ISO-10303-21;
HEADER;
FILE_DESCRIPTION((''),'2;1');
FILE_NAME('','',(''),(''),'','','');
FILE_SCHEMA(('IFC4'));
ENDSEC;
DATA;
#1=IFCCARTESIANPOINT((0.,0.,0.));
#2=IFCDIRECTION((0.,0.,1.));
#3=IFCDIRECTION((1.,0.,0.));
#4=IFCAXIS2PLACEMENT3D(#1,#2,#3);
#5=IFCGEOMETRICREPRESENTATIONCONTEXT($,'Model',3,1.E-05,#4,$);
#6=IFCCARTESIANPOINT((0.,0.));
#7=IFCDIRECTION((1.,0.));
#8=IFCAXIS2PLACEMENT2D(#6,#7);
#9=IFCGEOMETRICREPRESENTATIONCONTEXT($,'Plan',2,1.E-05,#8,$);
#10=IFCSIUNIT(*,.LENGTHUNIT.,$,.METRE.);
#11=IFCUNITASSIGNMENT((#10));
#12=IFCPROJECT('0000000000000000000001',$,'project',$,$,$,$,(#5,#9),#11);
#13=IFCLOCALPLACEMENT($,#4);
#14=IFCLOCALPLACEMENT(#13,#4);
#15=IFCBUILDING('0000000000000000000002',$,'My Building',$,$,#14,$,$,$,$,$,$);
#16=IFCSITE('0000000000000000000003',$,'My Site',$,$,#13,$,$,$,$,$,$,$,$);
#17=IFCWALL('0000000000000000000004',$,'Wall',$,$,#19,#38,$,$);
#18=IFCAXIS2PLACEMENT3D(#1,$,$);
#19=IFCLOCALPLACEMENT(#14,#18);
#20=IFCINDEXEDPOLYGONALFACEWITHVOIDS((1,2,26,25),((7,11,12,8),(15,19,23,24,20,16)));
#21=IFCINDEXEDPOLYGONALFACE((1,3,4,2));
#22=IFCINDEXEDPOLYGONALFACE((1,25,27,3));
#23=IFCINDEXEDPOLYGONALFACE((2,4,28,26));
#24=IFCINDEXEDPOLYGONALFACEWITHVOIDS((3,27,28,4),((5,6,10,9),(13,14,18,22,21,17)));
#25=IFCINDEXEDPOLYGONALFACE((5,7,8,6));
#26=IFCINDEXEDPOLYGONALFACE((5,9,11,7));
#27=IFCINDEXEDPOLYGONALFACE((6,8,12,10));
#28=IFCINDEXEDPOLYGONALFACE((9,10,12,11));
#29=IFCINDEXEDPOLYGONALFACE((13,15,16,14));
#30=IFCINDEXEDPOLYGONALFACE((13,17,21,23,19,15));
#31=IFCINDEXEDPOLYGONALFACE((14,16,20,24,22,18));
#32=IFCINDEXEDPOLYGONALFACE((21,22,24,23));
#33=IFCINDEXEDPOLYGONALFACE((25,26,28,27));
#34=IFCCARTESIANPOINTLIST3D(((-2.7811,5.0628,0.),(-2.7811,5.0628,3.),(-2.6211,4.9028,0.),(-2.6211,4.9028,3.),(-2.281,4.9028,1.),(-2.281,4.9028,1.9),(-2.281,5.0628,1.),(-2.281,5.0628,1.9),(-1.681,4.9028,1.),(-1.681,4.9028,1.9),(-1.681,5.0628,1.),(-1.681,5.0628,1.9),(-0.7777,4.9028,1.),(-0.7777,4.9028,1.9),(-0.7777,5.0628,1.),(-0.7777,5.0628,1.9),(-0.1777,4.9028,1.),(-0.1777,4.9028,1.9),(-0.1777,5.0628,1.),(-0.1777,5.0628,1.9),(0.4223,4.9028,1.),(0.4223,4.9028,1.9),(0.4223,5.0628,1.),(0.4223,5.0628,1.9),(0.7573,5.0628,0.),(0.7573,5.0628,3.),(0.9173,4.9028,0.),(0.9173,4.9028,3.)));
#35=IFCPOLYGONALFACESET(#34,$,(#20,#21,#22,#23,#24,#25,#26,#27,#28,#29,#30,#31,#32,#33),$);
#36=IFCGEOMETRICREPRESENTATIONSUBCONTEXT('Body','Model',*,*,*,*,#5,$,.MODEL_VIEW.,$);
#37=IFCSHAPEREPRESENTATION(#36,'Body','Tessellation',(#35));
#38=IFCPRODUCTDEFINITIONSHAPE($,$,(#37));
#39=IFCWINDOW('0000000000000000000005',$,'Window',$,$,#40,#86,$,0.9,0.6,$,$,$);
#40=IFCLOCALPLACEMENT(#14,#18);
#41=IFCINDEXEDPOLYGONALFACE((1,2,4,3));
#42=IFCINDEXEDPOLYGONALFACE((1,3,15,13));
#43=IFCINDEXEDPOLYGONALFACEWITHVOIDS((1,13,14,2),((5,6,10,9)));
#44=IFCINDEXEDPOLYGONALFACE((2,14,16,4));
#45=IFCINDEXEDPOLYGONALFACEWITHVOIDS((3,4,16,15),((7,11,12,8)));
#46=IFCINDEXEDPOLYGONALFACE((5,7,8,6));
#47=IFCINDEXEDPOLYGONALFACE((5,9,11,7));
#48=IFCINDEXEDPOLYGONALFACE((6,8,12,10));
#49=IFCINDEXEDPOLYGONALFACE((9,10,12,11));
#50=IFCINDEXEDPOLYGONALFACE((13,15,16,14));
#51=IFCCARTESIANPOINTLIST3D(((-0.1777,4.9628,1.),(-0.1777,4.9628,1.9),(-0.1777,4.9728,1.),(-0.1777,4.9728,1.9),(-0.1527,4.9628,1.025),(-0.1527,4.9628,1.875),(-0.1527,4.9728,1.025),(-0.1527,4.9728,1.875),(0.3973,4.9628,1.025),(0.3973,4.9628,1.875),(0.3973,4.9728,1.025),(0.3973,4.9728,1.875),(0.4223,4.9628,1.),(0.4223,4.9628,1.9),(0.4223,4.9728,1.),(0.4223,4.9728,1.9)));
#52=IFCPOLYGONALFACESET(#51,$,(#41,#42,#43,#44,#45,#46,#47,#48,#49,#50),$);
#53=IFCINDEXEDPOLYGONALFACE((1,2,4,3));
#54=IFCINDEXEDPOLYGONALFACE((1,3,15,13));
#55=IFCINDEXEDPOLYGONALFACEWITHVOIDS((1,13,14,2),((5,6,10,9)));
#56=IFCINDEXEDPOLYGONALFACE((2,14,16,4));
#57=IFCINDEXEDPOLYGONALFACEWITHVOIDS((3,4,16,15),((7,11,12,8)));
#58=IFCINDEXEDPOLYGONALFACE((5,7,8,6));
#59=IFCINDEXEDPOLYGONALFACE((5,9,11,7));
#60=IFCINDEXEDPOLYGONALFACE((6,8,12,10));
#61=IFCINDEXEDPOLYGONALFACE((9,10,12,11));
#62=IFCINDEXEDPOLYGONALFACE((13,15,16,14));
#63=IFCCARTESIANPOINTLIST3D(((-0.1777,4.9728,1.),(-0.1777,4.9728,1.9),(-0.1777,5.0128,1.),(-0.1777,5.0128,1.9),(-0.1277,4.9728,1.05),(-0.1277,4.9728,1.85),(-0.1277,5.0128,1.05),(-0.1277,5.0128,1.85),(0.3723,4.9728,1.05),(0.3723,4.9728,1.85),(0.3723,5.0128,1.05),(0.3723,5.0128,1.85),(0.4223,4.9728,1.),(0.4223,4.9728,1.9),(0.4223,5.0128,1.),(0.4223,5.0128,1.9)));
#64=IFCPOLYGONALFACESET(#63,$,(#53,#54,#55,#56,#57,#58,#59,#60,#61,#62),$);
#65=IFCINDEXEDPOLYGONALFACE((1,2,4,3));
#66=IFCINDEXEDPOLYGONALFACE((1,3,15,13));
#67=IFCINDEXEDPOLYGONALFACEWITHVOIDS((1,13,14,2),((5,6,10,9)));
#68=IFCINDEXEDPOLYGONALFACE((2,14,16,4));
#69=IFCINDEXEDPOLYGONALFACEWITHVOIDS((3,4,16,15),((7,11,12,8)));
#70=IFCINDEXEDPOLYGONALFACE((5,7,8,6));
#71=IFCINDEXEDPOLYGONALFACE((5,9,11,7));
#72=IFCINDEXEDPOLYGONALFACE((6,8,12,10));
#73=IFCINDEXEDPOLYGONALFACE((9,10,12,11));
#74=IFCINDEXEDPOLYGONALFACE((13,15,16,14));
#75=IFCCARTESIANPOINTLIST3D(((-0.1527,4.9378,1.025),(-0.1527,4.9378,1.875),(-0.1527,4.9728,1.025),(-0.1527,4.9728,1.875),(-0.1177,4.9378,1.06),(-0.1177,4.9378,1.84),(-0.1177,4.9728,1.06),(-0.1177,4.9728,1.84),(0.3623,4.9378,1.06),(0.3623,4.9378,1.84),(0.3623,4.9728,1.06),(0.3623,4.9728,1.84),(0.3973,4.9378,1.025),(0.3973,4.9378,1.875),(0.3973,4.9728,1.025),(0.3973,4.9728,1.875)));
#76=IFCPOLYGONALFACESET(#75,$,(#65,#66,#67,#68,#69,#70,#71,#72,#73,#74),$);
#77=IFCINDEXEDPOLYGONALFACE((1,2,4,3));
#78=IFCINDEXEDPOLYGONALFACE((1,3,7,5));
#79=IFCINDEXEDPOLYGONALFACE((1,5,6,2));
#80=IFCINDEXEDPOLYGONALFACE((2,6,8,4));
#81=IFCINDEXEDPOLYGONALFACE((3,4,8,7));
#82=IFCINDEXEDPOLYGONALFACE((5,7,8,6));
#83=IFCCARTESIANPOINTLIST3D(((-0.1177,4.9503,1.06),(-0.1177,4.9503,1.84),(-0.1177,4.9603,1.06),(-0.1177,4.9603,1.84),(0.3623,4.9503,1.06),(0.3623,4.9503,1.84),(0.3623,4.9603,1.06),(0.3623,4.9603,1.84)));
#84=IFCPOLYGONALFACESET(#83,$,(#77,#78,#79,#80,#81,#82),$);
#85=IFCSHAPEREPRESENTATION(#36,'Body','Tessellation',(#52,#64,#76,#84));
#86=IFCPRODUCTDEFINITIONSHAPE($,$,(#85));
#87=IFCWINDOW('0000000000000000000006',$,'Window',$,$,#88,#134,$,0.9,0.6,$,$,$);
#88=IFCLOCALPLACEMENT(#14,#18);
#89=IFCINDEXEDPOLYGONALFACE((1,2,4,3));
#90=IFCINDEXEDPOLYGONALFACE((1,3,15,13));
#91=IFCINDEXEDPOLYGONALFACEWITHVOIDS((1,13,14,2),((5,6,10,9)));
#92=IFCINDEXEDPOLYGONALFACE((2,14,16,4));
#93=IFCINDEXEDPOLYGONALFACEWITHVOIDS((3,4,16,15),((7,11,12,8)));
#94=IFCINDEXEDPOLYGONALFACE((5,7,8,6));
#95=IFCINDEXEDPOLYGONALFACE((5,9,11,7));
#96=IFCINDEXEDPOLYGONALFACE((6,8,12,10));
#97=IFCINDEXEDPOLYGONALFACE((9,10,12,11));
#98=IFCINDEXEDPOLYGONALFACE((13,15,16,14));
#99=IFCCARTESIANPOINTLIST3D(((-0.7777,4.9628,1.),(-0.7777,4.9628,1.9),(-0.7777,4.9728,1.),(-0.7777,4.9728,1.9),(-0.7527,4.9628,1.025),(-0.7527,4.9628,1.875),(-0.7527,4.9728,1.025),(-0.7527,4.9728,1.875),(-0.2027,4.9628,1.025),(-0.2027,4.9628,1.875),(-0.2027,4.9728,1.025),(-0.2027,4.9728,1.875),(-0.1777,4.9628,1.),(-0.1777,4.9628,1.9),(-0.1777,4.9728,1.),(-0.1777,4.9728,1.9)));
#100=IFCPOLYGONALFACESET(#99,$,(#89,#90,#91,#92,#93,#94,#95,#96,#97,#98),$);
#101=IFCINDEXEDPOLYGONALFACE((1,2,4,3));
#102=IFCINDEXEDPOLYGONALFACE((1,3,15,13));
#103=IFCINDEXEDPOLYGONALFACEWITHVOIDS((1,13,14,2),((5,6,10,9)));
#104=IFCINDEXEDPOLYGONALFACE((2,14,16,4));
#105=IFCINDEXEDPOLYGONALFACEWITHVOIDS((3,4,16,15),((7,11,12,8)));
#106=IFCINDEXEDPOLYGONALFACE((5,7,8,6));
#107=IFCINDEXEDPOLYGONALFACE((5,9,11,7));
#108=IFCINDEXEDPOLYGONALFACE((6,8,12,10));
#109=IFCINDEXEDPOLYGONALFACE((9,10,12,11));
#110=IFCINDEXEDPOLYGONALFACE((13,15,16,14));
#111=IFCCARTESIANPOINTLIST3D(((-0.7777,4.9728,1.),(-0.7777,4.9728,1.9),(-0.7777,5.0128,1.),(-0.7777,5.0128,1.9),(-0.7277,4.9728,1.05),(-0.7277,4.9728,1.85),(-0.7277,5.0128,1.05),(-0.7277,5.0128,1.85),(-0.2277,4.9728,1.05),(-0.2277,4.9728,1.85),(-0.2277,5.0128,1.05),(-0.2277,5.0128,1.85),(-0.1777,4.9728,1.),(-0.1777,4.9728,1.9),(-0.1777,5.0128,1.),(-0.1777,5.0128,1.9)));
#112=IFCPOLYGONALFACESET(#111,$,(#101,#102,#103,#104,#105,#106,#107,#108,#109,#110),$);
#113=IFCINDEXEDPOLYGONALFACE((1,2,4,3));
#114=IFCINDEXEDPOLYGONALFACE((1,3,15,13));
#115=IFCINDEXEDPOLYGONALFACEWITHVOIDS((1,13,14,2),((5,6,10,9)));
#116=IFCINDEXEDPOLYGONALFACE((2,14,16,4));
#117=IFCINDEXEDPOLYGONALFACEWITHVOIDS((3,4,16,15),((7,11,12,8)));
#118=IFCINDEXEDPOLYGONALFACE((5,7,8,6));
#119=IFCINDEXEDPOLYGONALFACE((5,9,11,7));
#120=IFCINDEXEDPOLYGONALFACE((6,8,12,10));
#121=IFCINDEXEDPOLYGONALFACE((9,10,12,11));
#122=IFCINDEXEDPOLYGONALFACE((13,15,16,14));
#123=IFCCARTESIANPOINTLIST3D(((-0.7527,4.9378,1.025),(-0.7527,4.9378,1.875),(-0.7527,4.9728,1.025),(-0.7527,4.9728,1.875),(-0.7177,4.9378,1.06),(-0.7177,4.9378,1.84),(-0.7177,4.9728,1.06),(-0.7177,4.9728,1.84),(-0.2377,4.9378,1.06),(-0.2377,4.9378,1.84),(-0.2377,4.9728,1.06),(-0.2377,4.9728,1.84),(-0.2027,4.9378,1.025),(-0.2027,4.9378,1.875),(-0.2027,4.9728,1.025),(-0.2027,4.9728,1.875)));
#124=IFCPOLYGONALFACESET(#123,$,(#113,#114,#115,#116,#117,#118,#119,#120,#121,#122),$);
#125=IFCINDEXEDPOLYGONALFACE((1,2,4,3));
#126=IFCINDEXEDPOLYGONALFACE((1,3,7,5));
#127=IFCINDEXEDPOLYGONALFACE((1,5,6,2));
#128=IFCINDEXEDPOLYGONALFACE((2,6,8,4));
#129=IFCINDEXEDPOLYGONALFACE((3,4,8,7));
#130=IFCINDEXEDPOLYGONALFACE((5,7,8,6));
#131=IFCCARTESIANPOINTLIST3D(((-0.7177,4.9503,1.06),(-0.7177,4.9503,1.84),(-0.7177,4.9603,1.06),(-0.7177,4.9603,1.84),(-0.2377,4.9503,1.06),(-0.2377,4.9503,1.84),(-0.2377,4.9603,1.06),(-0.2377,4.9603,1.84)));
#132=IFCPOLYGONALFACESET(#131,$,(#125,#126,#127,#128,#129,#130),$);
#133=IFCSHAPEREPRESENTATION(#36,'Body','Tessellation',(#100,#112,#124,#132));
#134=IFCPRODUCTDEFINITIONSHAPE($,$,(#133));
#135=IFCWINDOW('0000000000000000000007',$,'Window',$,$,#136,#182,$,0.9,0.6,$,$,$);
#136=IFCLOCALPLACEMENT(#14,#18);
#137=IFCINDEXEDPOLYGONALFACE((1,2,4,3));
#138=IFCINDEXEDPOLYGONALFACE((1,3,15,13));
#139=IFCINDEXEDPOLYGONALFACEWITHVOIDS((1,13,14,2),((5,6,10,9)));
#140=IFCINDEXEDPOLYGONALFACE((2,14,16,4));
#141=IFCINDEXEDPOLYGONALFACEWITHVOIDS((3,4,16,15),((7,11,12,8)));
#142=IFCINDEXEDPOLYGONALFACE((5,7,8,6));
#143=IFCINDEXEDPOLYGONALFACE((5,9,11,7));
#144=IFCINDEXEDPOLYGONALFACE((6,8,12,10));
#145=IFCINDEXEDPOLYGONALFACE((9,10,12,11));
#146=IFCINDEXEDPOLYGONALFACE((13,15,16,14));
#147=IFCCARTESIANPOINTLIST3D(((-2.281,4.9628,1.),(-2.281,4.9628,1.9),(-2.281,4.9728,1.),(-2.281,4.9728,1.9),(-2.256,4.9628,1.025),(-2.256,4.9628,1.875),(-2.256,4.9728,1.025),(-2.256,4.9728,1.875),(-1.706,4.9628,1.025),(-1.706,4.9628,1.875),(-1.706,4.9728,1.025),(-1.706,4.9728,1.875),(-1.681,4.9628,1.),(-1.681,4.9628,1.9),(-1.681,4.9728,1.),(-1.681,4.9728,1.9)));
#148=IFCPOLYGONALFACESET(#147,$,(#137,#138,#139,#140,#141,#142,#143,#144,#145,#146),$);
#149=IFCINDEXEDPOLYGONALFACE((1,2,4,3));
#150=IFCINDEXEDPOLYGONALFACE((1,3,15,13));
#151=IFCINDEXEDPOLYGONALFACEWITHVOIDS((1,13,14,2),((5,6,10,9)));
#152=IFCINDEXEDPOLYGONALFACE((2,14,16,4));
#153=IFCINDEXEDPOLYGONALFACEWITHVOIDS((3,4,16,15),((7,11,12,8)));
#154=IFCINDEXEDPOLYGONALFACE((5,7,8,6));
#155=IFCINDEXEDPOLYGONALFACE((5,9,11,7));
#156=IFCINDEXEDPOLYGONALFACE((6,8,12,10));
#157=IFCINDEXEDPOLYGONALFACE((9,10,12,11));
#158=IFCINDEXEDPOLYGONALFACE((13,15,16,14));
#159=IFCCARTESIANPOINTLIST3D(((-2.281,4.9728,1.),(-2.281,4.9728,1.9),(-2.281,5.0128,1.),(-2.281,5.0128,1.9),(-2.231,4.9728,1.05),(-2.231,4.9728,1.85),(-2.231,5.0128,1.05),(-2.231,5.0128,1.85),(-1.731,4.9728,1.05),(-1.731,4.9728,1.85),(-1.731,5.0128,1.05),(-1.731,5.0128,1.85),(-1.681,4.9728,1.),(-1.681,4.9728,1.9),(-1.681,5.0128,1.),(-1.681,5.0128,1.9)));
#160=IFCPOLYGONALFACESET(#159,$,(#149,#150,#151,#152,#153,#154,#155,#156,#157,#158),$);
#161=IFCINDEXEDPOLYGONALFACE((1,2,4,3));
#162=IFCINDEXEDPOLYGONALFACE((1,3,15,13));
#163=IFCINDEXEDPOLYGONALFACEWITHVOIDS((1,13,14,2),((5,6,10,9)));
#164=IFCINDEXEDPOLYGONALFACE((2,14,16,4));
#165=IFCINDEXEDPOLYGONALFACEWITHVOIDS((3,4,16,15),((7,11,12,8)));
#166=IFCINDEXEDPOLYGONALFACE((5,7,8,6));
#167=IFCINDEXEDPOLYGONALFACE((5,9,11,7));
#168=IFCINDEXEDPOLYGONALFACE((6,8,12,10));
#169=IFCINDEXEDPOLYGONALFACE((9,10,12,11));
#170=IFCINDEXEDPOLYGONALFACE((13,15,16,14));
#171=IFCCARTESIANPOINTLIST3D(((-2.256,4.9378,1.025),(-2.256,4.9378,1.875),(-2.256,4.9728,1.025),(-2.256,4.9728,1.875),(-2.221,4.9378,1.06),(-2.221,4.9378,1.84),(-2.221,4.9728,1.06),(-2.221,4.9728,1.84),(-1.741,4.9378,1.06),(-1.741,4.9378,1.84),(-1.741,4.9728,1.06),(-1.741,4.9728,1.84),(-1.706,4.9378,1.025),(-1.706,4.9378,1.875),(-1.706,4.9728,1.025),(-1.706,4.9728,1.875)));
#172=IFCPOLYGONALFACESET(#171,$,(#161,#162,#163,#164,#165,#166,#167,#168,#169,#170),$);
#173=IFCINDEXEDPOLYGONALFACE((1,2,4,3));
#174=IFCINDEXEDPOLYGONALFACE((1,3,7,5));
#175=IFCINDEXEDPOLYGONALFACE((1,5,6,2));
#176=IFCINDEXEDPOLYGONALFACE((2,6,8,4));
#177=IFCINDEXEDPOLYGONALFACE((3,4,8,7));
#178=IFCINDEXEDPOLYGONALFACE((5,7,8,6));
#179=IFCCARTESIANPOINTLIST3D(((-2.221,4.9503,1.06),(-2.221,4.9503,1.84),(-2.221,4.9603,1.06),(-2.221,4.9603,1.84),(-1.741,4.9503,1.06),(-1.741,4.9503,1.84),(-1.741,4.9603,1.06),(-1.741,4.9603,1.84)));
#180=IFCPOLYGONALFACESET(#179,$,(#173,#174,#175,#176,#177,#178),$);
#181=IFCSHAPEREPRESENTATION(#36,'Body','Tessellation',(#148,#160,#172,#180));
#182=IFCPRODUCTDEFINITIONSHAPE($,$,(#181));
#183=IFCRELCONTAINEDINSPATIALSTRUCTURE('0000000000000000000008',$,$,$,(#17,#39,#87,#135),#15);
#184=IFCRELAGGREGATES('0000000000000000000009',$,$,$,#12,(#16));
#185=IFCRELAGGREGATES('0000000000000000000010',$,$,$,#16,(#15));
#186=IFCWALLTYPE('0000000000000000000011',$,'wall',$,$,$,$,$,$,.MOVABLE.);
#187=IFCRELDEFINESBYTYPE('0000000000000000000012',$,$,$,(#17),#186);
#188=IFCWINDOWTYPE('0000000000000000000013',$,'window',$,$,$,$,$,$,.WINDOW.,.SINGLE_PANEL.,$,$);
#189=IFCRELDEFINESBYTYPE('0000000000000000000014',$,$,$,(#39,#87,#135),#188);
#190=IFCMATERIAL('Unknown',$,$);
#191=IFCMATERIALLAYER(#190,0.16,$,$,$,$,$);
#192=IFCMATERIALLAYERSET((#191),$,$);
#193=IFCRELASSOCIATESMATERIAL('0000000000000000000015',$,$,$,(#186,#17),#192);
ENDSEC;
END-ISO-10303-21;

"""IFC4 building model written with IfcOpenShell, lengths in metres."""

from ifc_helpers import new_model, entity, si_unit, frame, origin_with_axes, origin_2d_with_axis, place, context, subcontext, project, spatial, line, indexed_curve, outline, extrude, shape, source, transform, mapped, material, layer, layer_set, layer_usage, type_object, type_shapes, element, fill, save


model = new_model("IFC4")

# Units and contexts
model_context = context("Model", 3, precision=1e-05, world=origin_with_axes())
plan_context = context("Plan", 2, precision=1e-05, world=origin_2d_with_axis())
body_context_1 = subcontext(model_context, "Body", "Model", "MODEL_VIEW")
body_context_2 = subcontext(plan_context, "Body", "Plan", "PLAN_VIEW")
ifc_project = project(units=[si_unit("LENGTHUNIT", "METRE")], contexts=[model_context, plan_context])

# Site, building
site_placement = place(None, origin_with_axes())
site = spatial("IfcSite", under=ifc_project, at=site_placement, Name="My Site")
building_placement = place(site_placement, origin_with_axes())
building = spatial("IfcBuilding", under=site, at=building_placement, Name="My Building")

# Shared definitions
ifc_material = material(Name="Unknown")

# Wall, openings, windows
ifc_layer_1 = layer(ifc_material, 0.16)
ifc_layer_set_1 = layer_set([ifc_layer_1])
ifc_layer_usage_1 = layer_usage(ifc_layer_set_1, "AXIS2", "POSITIVE", 0.0)
wall_type_1 = type_object("IfcWallType", Name="wall", PredefinedType="MOVABLE", material=ifc_layer_set_1)
wall_1_placement = place(building_placement, frame((-2.6211, 4.9028, 0.0), z_axis=(0.0, 0.0, 1.0), x_axis=(1.0, 0.0, 0.0)))
wall_1 = element("IfcWall", 1, at=wall_1_placement, inside=building, type_object=wall_type_1, material=ifc_layer_usage_1, Name="Wall", context=body_context_1, shape_type="SweptSolid", body=[
    extrude(outline(indexed_curve([(0.0, 0.0), (-0.16, 0.16), (3.3784, 0.16), (3.5384, 0.0)], segments=[line(1, 2, 3, 4, 1)])), origin_with_axes(), (0.0, 0.0, 1.0), 3.0),
])
shared_shape_1 = source(origin_with_axes(), body_context_1, "Body", "SweptSolid", [
    extrude(outline(indexed_curve([(0.0, 0.0), (0.6, 0.0), (0.6, 0.9), (0.0, 0.9)], segments=[line(1, 2, 3, 4, 1)])), frame((0.0, -0.6, 0.0), z_axis=(0.0, -1.0, 0.0), x_axis=(1.0, 0.0, 0.0)), (0.0, 0.0, -1.0), 1.2),
])
opening_1_placement = place(wall_1_placement, frame((3.0434, 0.16, 1.0), z_axis=(0.0, 0.0, 1.0), x_axis=(-1.0, 0.0, 0.0)))
opening_1 = element("IfcOpeningElement", 2, at=opening_1_placement, cuts=wall_1, PredefinedType="OPENING", context=body_context_1, shape_type="MappedRepresentation", body=[
    mapped(shared_shape_1, transform((0.0, 0.0, 0.0), x_axis=(1.0, 0.0, 0.0), y_axis=(0.0, 1.0, 0.0), z_axis=(0.0, 0.0, 1.0), scale=1.0)),
])
opening_2_placement = place(wall_1_placement, frame((2.4434, 0.16, 1.0), z_axis=(0.0, 0.0, 1.0), x_axis=(-1.0, 0.0, 0.0)))
opening_2 = element("IfcOpeningElement", 3, at=opening_2_placement, cuts=wall_1, PredefinedType="OPENING", context=body_context_1, shape_type="MappedRepresentation", body=[
    mapped(shared_shape_1, transform((0.0, 0.0, 0.0), x_axis=(1.0, 0.0, 0.0), y_axis=(0.0, 1.0, 0.0), z_axis=(0.0, 0.0, 1.0), scale=1.0)),
])
opening_3_placement = place(wall_1_placement, frame((0.9401, 0.16, 1.0), z_axis=(0.0, 0.0, 1.0), x_axis=(-1.0, 0.0, 0.0)))
opening_3 = element("IfcOpeningElement", 4, at=opening_3_placement, cuts=wall_1, PredefinedType="OPENING", context=body_context_1, shape_type="MappedRepresentation", body=[
    mapped(shared_shape_1, transform((0.0, 0.0, 0.0), x_axis=(1.0, 0.0, 0.0), y_axis=(0.0, 1.0, 0.0), z_axis=(0.0, 0.0, 1.0), scale=1.0)),
])
window_type = type_object("IfcWindowType", Name="window", PartitioningType="SINGLE_PANEL", PredefinedType="WINDOW")
shared_shape_2 = source(origin_with_axes(), body_context_1, "Body", "SweptSolid", [
    extrude(outline(indexed_curve([(0.0, 0.0), (0.6, 0.0), (0.6, 0.9), (0.0, 0.9)], segments=[line(1, 2, 3, 4, 1)]), holes=[indexed_curve([(0.025, 0.025), (0.575, 0.025), (0.575, 0.875), (0.025, 0.875)], segments=[line(1, 2, 3, 4, 1)])]), frame((0.0, 0.09, 0.0), z_axis=(0.0, -1.0, 0.0), x_axis=(1.0, 0.0, 0.0)), (0.0, 0.0, -1.0), 0.01),
    extrude(outline(indexed_curve([(0.0, 0.0), (0.6, 0.0), (0.6, 0.9), (0.0, 0.9)], segments=[line(1, 2, 3, 4, 1)]), holes=[indexed_curve([(0.05, 0.05), (0.55, 0.05), (0.55, 0.85), (0.05, 0.85)], segments=[line(1, 2, 3, 4, 1)])]), frame((0.0, 0.05, 0.0), z_axis=(0.0, -1.0, 0.0), x_axis=(1.0, 0.0, 0.0)), (0.0, 0.0, -1.0), 0.04),
    extrude(outline(indexed_curve([(0.0, 0.0), (0.55, 0.0), (0.55, 0.85), (0.0, 0.85)], segments=[line(1, 2, 3, 4, 1)]), holes=[indexed_curve([(0.035, 0.035), (0.515, 0.035), (0.515, 0.815), (0.035, 0.815)], segments=[line(1, 2, 3, 4, 1)])]), frame((0.025, 0.09, 0.025), z_axis=(0.0, -1.0, 0.0), x_axis=(1.0, 0.0, 0.0)), (0.0, 0.0, -1.0), 0.035),
    extrude(outline(indexed_curve([(0.035, 0.035), (0.515, 0.035), (0.515, 0.815), (0.035, 0.815)], segments=[line(1, 2, 3, 4, 1)])), frame((0.025, 0.1025, 0.025), z_axis=(0.0, -1.0, 0.0), x_axis=(1.0, 0.0, 0.0)), (0.0, 0.0, -1.0), 0.01),
])
shared_shape_3 = source(origin_with_axes(), body_context_2, "Body", "Curve2D", [
    entity("IfcIndexedPolyCurve", entity("IfcCartesianPointList2D", [[0.05, 0.05], [0.55, 0.05]])),
    entity("IfcIndexedPolyCurve", entity("IfcCartesianPointList2D", [[0.0, 0.1], [0.025, 0.1], [0.025, 0.09], [0.05, 0.09], [0.05, 0.05], [0.0, 0.05]]), [entity("IfcLineIndex", [1, 2, 3, 4, 5, 6, 1])]),
    entity("IfcIndexedPolyCurve", entity("IfcCartesianPointList2D", [[0.6, 0.1], [0.575, 0.1], [0.575, 0.09], [0.55, 0.09], [0.55, 0.05], [0.6, 0.05]]), [entity("IfcLineIndex", [1, 2, 3, 4, 5, 6, 1])]),
    entity("IfcIndexedPolyCurve", entity("IfcCartesianPointList2D", [[0.025, 0.09], [0.06, 0.09], [0.06, 0.125], [0.025, 0.125]]), [entity("IfcLineIndex", [1, 2, 3, 4, 1])]),
    entity("IfcIndexedPolyCurve", entity("IfcCartesianPointList2D", [[0.575, 0.09], [0.54, 0.09], [0.54, 0.125], [0.575, 0.125]]), [entity("IfcLineIndex", [1, 2, 3, 4, 1])]),
    entity("IfcIndexedPolyCurve", entity("IfcCartesianPointList2D", [[0.06, 0.09], [0.54, 0.09]])),
    entity("IfcIndexedPolyCurve", entity("IfcCartesianPointList2D", [[0.06, 0.125], [0.54, 0.125]])),
    entity("IfcIndexedPolyCurve", entity("IfcCartesianPointList2D", [[0.06, 0.1075], [0.54, 0.1075]])),
])
type_shapes(window_type, [shared_shape_2, shared_shape_3])
window_1_placement = place(opening_1_placement, frame((0.0, 0.0, 0.0), z_axis=(0.0, 0.0, 1.0), x_axis=(1.0, 0.0, 0.0)))
window_1 = element("IfcWindow", 5, at=window_1_placement, inside=building, type_object=window_type, Name="Window", OverallHeight=0.9, OverallWidth=0.6, shapes=[
    shape(body_context_1, "Body", "MappedRepresentation", [mapped(shared_shape_2, transform((0.0, 0.0, 0.0), x_axis=(1.0, 0.0, 0.0), y_axis=(0.0, 1.0, 0.0), z_axis=(0.0, 0.0, 1.0), scale=1.0))]),
    shape(body_context_2, "Body", "MappedRepresentation", [mapped(shared_shape_3, transform((0.0, 0.0, 0.0), x_axis=(1.0, 0.0, 0.0), y_axis=(0.0, 1.0, 0.0), z_axis=(0.0, 0.0, 1.0), scale=1.0))]),
])
fill(opening_1, window_1)
window_2_placement = place(opening_2_placement, frame((0.0, 0.0, 0.0), z_axis=(0.0, 0.0, 1.0), x_axis=(1.0, 0.0, 0.0)))
window_2 = element("IfcWindow", 6, at=window_2_placement, inside=building, type_object=window_type, Name="Window", OverallHeight=0.9, OverallWidth=0.6, shapes=[
    shape(body_context_1, "Body", "MappedRepresentation", [mapped(shared_shape_2, transform((0.0, 0.0, 0.0), x_axis=(1.0, 0.0, 0.0), y_axis=(0.0, 1.0, 0.0), z_axis=(0.0, 0.0, 1.0), scale=1.0))]),
    shape(body_context_2, "Body", "MappedRepresentation", [mapped(shared_shape_3, transform((0.0, 0.0, 0.0), x_axis=(1.0, 0.0, 0.0), y_axis=(0.0, 1.0, 0.0), z_axis=(0.0, 0.0, 1.0), scale=1.0))]),
])
fill(opening_2, window_2)
window_3_placement = place(opening_3_placement, frame((0.0, 0.0, 0.0), z_axis=(0.0, 0.0, 1.0), x_axis=(1.0, 0.0, 0.0)))
window_3 = element("IfcWindow", 7, at=window_3_placement, inside=building, type_object=window_type, Name="Window", OverallHeight=0.9, OverallWidth=0.6, shapes=[
    shape(body_context_1, "Body", "MappedRepresentation", [mapped(shared_shape_2, transform((0.0, 0.0, 0.0), x_axis=(1.0, 0.0, 0.0), y_axis=(0.0, 1.0, 0.0), z_axis=(0.0, 0.0, 1.0), scale=1.0))]),
    shape(body_context_2, "Body", "MappedRepresentation", [mapped(shared_shape_3, transform((0.0, 0.0, 0.0), x_axis=(1.0, 0.0, 0.0), y_axis=(0.0, 1.0, 0.0), z_axis=(0.0, 0.0, 1.0), scale=1.0))]),
])
fill(opening_3, window_3)

save(model, "model.ifc")
